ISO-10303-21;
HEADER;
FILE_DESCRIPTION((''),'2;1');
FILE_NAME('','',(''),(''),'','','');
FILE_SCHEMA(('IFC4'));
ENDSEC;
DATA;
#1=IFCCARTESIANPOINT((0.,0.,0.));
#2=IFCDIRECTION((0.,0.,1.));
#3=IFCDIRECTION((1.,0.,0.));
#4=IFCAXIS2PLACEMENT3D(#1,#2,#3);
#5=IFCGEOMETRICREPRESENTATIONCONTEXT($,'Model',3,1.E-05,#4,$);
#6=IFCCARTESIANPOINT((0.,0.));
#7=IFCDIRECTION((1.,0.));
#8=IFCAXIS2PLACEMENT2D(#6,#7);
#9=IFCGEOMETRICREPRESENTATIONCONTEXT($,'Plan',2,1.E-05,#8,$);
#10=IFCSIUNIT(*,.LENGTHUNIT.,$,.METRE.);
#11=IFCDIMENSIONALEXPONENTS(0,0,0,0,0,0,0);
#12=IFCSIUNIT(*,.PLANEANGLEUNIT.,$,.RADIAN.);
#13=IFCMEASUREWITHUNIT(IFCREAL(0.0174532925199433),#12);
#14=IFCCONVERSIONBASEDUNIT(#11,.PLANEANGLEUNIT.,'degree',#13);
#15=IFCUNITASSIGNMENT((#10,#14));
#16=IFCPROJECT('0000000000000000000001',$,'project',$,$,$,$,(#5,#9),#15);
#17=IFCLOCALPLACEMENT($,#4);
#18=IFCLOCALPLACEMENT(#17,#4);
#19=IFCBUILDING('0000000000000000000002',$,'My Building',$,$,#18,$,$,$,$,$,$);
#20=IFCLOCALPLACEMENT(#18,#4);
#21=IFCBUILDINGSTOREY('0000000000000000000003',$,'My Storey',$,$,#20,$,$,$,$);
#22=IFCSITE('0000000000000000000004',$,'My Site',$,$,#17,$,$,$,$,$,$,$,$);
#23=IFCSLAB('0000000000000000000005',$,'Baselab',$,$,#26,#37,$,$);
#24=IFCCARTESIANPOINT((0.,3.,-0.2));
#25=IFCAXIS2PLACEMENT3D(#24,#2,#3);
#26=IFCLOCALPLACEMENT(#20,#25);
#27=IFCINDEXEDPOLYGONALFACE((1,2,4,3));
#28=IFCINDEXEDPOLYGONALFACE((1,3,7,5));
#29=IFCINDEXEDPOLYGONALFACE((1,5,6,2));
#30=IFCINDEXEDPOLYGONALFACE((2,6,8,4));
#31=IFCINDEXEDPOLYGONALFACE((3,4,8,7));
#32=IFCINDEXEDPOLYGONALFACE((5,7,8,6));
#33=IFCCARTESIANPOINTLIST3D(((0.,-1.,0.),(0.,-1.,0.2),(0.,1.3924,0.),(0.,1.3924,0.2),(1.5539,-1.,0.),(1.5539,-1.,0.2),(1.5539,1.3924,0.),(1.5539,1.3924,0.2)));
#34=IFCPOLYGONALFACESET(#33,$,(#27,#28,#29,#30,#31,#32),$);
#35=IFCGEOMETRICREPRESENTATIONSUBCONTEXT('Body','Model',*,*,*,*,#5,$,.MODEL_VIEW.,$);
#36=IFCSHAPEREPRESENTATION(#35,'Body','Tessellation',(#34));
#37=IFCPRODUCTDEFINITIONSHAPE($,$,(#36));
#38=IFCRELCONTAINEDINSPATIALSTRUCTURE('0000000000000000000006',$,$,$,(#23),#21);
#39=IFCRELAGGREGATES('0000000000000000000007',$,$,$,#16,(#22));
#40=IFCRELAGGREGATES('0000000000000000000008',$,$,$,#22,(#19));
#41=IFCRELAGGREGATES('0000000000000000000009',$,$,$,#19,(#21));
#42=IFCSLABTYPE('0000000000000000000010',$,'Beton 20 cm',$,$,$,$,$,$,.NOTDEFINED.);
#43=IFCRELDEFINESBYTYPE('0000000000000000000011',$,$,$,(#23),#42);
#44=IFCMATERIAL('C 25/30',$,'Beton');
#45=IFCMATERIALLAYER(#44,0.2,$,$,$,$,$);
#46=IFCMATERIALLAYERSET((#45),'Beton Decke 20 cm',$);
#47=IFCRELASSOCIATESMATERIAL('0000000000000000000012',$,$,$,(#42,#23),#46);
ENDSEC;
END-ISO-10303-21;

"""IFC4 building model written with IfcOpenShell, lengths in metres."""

from ifc_helpers import new_model, entity, si_unit, converted_unit, frame, origin_with_axes, origin_2d_with_axis, place, context, subcontext, project, spatial, line, indexed_curve, outline, extrude, material, layer, layer_set, layer_usage, type_object, element, save


model = new_model("IFC4")

# Units and contexts
model_context = context("Model", 3, precision=1e-05, world=origin_with_axes())
plan_context = context("Plan", 2, precision=1e-05, world=origin_2d_with_axis())
body_context = subcontext(model_context, "Body", "Model", "MODEL_VIEW")
ifc_project = project(units=[si_unit("LENGTHUNIT", "METRE"), converted_unit("PLANEANGLEUNIT", "degree", entity("IfcReal", 0.0174532925199433), si_unit("PLANEANGLEUNIT", "RADIAN"), dimensions=[0, 0, 0, 0, 0, 0, 0])], contexts=[model_context, plan_context])

# Site, building, storey
site_placement = place(None, origin_with_axes())
site = spatial("IfcSite", under=ifc_project, at=site_placement, Name="My Site")
building_placement = place(site_placement, origin_with_axes())
building = spatial("IfcBuilding", under=site, at=building_placement, Name="My Building")
storey_placement = place(building_placement, origin_with_axes())
storey = spatial("IfcBuildingStorey", under=building, at=storey_placement, Name="My Storey")

# Slab
ifc_material = material(Name="C 25/30", Category="Beton")
ifc_layer = layer(ifc_material, 0.2)
ifc_layer_set = layer_set([ifc_layer], Name="Beton Decke 20 cm")
ifc_layer_usage_1 = layer_usage(ifc_layer_set, "AXIS3", "POSITIVE", 0.0)
slab_type = type_object("IfcSlabType", Name="Beton 20 cm", PredefinedType="NOTDEFINED", material=ifc_layer_set)
slab_1_placement = place(storey_placement, frame((0.0, 3.0, -0.2), z_axis=(0.0, 0.0, 1.0), x_axis=(1.0, 0.0, 0.0)))
element("IfcSlab", 1, at=slab_1_placement, inside=storey, type_object=slab_type, material=ifc_layer_usage_1, Name="Baselab", context=body_context, shape_type="SweptSolid", body=[
    extrude(outline(indexed_curve([(1.5539, 1.3924), (1.5539, -1.0), (0.0, -1.0), (0.0, 1.3924)], segments=[line(3, 2), line(2, 1), line(1, 4), line(4, 3)], self_intersect=False)), None, (0.0, 0.0, 1.0), 0.2),
])

save(model, "model.ifc")
